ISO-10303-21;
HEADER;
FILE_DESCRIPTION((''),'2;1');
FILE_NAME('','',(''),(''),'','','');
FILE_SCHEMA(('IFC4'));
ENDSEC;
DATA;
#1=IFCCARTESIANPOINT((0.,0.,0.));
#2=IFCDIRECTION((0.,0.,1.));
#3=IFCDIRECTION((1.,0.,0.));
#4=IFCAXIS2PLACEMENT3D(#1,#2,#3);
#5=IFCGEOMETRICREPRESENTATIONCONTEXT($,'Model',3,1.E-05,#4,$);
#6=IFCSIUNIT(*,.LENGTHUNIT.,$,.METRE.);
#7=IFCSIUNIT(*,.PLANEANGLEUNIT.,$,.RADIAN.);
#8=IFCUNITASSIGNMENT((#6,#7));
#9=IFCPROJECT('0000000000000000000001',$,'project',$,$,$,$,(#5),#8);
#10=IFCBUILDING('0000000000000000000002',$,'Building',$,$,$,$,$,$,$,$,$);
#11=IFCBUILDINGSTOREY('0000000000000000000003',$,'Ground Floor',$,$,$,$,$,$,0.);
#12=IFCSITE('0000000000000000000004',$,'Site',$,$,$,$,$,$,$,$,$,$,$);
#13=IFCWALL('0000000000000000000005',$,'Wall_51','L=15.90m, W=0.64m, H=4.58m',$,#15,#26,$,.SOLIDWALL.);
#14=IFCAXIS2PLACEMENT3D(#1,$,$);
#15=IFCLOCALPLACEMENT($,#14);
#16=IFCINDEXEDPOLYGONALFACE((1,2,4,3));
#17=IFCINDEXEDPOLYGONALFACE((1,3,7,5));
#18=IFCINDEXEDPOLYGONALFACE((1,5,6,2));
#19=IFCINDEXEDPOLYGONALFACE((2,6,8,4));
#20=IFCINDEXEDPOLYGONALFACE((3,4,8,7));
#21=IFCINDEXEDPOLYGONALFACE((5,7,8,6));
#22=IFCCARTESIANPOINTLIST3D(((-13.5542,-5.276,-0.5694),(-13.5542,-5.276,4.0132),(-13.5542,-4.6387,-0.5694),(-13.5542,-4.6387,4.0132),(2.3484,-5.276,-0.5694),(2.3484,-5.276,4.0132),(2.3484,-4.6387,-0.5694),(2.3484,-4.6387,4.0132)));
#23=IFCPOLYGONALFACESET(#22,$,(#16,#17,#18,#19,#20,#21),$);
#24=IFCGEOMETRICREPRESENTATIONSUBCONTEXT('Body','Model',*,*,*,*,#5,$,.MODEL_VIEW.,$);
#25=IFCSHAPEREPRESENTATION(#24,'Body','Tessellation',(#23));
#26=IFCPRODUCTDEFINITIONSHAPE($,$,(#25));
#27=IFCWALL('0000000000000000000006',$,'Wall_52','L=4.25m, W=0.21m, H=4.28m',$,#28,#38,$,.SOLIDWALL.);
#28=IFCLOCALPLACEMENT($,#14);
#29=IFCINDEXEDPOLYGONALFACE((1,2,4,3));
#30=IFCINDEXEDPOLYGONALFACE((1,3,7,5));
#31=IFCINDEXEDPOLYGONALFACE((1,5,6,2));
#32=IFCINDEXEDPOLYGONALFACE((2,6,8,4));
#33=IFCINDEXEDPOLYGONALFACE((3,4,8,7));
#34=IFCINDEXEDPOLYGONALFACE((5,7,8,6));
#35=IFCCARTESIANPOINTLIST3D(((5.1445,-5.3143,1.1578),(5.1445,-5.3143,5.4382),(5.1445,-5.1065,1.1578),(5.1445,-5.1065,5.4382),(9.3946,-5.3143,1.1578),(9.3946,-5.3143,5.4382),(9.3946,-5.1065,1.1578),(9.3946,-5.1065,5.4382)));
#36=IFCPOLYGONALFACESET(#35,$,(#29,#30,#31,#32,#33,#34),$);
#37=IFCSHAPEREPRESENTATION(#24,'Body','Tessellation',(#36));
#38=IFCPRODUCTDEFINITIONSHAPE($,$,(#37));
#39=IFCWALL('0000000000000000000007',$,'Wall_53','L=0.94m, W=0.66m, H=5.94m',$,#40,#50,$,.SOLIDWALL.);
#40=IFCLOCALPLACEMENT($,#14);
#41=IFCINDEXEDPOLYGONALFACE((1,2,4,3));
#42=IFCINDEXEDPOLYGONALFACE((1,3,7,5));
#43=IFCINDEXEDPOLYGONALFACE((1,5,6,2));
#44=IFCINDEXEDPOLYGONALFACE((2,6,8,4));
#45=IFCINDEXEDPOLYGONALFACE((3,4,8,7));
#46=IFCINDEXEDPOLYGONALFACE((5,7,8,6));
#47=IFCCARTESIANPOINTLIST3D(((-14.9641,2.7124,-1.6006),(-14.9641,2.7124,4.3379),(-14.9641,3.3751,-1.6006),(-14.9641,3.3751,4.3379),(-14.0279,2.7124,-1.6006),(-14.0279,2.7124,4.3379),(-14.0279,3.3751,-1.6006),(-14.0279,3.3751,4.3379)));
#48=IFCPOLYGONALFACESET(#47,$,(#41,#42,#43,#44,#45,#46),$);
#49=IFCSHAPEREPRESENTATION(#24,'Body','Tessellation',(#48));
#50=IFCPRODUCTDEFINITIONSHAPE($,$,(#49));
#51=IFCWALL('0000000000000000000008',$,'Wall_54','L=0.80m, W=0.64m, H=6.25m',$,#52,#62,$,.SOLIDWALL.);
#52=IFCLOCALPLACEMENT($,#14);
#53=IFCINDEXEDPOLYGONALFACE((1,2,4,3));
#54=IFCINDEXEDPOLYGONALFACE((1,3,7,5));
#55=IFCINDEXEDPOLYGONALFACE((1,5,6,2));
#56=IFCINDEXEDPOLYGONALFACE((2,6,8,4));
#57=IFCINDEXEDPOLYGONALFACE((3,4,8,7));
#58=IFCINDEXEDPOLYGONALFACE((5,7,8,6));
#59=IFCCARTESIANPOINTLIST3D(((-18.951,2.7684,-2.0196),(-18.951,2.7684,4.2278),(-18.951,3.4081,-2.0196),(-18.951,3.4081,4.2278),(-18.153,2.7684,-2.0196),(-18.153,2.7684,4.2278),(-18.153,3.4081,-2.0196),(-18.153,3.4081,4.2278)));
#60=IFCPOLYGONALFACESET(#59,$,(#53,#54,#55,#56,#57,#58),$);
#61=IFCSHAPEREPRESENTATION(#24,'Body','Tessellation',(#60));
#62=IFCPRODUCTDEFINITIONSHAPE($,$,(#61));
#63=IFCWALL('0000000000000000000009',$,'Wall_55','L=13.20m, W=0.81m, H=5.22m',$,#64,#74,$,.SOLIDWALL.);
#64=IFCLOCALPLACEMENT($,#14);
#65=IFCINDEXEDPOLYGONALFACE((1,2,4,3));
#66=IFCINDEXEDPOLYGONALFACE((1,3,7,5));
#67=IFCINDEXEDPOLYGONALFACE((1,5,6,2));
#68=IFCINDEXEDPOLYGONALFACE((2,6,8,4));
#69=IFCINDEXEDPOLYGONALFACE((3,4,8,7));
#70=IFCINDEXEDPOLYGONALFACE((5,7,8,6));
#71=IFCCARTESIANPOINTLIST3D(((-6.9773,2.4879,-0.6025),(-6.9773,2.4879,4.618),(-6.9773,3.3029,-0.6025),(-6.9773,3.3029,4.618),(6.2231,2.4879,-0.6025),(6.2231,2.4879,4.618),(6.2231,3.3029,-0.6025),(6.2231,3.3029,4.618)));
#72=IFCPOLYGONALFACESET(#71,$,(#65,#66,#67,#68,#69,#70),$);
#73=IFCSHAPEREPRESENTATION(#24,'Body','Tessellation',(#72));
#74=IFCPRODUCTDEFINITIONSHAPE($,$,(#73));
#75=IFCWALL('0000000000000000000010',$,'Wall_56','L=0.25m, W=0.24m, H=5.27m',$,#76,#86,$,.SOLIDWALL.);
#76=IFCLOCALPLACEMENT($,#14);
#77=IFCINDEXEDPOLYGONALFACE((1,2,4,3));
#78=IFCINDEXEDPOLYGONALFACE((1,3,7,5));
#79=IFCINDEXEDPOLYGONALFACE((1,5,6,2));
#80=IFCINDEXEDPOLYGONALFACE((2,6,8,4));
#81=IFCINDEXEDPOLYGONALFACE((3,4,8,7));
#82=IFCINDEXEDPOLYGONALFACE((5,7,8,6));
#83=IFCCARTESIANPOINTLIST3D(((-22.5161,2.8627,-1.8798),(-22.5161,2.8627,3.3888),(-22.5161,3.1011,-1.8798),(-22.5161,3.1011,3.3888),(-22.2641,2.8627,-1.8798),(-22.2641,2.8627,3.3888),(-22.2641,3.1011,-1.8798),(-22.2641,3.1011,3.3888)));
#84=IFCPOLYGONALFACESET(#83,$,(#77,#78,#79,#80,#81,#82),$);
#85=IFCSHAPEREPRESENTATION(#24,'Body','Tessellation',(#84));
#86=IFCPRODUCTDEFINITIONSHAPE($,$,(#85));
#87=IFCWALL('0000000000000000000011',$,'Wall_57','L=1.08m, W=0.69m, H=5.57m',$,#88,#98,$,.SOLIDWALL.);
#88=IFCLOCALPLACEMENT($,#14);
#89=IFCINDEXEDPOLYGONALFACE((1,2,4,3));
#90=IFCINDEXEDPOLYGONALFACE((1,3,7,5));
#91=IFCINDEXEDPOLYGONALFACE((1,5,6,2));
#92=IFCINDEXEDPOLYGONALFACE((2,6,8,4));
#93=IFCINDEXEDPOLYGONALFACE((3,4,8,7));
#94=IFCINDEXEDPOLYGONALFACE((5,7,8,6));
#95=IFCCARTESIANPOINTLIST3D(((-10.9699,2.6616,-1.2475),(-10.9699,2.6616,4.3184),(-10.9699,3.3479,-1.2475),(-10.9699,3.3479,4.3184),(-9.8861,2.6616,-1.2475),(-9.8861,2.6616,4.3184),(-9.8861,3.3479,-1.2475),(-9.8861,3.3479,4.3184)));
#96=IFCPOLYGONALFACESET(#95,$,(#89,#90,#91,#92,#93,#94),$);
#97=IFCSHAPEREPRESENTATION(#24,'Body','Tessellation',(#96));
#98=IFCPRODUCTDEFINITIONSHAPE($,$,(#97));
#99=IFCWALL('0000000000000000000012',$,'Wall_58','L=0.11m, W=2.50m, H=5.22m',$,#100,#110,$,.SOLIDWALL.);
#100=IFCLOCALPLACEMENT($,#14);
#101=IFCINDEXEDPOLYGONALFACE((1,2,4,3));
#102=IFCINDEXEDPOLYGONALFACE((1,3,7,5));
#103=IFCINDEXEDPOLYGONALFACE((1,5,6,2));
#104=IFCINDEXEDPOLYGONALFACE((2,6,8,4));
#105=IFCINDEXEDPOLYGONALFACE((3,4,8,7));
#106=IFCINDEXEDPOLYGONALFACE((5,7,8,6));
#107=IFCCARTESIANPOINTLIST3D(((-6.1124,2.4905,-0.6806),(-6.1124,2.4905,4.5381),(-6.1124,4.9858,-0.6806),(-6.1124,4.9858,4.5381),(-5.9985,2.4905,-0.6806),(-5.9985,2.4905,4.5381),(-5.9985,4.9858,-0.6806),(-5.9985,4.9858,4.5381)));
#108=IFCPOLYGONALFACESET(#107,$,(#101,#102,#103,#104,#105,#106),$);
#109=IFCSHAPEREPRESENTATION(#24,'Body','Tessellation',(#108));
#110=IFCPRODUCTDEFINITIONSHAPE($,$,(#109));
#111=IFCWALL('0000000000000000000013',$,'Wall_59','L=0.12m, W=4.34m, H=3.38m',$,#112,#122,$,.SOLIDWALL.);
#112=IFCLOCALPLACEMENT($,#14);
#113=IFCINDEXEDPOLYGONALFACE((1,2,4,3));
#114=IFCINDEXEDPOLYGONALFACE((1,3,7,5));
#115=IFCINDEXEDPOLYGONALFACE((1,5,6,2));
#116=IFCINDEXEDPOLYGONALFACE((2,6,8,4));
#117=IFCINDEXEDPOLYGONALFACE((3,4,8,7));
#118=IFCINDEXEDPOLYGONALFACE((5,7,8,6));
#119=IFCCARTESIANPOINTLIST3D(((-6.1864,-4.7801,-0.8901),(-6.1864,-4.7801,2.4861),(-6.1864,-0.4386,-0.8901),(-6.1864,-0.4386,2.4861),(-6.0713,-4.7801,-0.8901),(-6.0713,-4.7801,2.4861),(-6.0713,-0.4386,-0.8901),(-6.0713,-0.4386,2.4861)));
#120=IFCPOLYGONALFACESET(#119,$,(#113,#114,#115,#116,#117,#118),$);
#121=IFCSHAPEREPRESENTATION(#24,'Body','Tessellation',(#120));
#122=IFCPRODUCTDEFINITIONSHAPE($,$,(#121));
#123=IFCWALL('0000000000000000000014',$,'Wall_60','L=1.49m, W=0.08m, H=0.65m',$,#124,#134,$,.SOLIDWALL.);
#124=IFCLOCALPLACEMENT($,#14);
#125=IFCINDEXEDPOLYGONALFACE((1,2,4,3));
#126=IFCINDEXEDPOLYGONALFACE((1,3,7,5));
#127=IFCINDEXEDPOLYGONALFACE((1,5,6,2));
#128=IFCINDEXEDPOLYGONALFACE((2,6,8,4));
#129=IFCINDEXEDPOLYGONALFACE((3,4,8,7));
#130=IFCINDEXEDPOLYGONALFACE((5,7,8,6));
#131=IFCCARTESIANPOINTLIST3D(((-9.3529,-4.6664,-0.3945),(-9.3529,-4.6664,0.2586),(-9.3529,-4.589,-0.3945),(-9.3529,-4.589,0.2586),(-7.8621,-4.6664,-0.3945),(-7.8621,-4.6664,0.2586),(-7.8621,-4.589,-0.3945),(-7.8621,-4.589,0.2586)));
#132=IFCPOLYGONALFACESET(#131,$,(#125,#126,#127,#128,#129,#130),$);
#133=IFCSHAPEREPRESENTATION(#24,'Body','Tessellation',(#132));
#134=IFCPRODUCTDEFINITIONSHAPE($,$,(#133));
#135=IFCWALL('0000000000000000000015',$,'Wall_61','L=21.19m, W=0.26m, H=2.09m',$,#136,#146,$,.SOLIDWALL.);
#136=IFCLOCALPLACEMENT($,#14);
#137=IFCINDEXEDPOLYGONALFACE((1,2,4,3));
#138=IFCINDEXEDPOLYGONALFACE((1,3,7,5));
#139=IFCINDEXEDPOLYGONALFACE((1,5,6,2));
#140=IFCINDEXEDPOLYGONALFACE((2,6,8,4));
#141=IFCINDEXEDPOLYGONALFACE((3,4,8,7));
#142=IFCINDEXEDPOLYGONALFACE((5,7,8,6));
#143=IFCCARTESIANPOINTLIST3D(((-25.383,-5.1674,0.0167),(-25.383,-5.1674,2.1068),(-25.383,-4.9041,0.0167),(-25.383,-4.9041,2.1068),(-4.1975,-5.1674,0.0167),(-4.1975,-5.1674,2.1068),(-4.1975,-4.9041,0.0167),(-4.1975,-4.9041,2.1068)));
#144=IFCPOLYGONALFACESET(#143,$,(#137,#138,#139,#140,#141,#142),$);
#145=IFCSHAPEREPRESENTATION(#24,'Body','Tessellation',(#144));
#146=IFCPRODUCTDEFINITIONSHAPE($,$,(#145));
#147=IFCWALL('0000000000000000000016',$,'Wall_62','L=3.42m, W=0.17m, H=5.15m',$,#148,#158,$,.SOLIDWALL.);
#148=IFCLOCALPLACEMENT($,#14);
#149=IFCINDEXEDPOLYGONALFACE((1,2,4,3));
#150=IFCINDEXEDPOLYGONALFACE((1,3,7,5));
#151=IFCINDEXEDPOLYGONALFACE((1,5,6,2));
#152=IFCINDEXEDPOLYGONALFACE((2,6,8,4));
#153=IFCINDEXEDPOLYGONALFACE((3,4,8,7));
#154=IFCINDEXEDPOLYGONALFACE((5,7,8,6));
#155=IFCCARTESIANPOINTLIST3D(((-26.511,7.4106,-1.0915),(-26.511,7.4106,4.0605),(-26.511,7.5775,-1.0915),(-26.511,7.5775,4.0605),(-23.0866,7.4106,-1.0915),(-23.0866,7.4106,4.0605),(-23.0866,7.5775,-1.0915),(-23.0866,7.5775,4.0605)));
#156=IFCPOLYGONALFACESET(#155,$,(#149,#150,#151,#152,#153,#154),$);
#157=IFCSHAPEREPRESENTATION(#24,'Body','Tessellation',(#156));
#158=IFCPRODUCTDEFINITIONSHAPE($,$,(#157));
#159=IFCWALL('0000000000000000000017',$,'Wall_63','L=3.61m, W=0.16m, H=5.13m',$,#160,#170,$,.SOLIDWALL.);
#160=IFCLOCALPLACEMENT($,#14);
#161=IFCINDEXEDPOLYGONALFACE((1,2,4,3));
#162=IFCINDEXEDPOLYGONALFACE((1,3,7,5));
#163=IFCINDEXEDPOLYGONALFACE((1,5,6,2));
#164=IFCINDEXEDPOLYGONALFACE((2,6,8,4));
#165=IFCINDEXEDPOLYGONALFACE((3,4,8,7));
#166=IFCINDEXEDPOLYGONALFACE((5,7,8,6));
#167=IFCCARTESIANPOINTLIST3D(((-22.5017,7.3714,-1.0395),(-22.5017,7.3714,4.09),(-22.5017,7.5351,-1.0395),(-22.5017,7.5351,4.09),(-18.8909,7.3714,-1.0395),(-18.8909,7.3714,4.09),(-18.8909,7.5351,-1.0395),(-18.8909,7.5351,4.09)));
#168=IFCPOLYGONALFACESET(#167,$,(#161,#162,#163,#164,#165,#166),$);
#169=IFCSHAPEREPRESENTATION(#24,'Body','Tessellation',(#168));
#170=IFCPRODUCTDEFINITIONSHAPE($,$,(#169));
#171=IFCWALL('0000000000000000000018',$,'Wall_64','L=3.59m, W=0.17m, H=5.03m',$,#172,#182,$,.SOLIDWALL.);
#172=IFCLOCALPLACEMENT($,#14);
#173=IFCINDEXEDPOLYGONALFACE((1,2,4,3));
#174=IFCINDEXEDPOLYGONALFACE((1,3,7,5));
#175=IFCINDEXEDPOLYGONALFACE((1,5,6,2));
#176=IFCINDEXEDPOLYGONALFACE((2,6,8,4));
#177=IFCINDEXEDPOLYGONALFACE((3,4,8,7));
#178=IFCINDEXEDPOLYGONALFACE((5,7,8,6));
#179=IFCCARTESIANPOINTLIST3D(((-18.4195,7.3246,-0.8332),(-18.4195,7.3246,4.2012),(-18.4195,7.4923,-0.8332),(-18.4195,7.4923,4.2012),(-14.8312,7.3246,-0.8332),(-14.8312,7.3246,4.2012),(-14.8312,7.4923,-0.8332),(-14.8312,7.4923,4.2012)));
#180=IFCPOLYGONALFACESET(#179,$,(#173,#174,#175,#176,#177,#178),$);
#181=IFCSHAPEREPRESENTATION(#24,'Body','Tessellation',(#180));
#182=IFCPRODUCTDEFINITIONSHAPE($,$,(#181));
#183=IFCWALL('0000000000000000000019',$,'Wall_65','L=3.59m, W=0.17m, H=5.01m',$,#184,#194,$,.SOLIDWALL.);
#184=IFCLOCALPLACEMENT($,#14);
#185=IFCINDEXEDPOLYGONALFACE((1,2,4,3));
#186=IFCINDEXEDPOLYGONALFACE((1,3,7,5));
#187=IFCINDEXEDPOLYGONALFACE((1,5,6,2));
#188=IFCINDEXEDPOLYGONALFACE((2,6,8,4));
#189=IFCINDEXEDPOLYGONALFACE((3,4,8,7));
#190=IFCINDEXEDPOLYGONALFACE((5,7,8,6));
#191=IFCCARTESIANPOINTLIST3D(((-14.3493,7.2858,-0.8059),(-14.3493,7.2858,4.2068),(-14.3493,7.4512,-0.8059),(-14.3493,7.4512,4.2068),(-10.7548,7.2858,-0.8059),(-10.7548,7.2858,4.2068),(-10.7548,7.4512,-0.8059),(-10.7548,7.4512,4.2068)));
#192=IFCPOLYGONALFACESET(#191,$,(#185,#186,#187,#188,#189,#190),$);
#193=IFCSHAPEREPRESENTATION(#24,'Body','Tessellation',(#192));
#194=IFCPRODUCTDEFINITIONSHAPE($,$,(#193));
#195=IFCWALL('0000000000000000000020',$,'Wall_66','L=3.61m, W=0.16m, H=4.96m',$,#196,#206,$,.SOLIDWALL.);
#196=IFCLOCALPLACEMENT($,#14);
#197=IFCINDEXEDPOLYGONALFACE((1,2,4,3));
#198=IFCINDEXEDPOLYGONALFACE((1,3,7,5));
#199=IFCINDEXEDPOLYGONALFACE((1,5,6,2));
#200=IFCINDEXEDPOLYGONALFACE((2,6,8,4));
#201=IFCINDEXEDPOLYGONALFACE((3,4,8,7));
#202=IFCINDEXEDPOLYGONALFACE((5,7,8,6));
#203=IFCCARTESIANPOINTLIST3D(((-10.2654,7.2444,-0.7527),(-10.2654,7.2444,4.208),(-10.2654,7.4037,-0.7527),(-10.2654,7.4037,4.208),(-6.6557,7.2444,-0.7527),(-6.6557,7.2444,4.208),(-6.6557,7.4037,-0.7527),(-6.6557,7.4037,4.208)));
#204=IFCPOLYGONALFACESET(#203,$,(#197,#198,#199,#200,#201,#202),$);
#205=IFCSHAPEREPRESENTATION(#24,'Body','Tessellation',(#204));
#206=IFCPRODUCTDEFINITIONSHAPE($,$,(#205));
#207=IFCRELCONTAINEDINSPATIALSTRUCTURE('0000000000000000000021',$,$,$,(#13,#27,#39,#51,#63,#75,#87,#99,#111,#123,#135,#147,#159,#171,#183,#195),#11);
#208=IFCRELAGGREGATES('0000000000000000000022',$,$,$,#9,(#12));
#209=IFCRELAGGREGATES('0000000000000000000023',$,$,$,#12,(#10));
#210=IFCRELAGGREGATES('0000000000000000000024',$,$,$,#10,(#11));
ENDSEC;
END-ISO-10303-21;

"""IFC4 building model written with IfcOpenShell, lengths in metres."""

from ifc_helpers import new_model, si_unit, frame, origin_with_axes, origin_2d, context, subcontext, project, spatial, rectangle, extrude, element, save


model = new_model("IFC4")

# Units and contexts
model_context = context("Model", 3, precision=1e-05, world=origin_with_axes())
body_context = subcontext(model_context, "Body", "Model", "MODEL_VIEW")
ifc_project = project(units=[si_unit("LENGTHUNIT", "METRE"), si_unit("PLANEANGLEUNIT", "RADIAN")], contexts=[model_context])

# Site, building, storey
site = spatial("IfcSite", under=ifc_project, Name="Site")
building = spatial("IfcBuilding", under=site, Name="Building")
storey = spatial("IfcBuildingStorey", under=building, Name="Ground Floor", Elevation=0.0)

# Walls
element("IfcWall", 1, inside=storey, Name="Wall_51", Description="L=15.90m, W=0.64m, H=4.58m", PredefinedType="SOLIDWALL", context=body_context, shape_type="SweptSolid", body=[
    extrude(rectangle(XDim=15.9026, YDim=0.6373, at=origin_2d()), frame((-5.6029, -4.9573, -0.5694), z_axis=(0.0, 0.0, 1.0), x_axis=(1.0, 0.0, 0.0)), (0.0, 0.0, 1.0), 4.5827),
])
element("IfcWall", 2, inside=storey, Name="Wall_52", Description="L=4.25m, W=0.21m, H=4.28m", PredefinedType="SOLIDWALL", context=body_context, shape_type="SweptSolid", body=[
    extrude(rectangle(XDim=4.2501, YDim=0.2079, at=origin_2d()), frame((7.2695, -5.2104, 1.1578), z_axis=(0.0, 0.0, 1.0), x_axis=(1.0, 0.0, 0.0)), (0.0, 0.0, 1.0), 4.2804),
])
element("IfcWall", 3, inside=storey, Name="Wall_53", Description="L=0.94m, W=0.66m, H=5.94m", PredefinedType="SOLIDWALL", context=body_context, shape_type="SweptSolid", body=[
    extrude(rectangle(XDim=0.9362, YDim=0.6626, at=origin_2d()), frame((-14.496, 3.0438, -1.6006), z_axis=(0.0, 0.0, 1.0), x_axis=(1.0, 0.0, 0.0)), (0.0, 0.0, 1.0), 5.9385),
])
element("IfcWall", 4, inside=storey, Name="Wall_54", Description="L=0.80m, W=0.64m, H=6.25m", PredefinedType="SOLIDWALL", context=body_context, shape_type="SweptSolid", body=[
    extrude(rectangle(XDim=0.7979, YDim=0.6396, at=origin_2d()), frame((-18.552, 3.0883, -2.0196), z_axis=(0.0, 0.0, 1.0), x_axis=(1.0, 0.0, 0.0)), (0.0, 0.0, 1.0), 6.2474),
])
element("IfcWall", 5, inside=storey, Name="Wall_55", Description="L=13.20m, W=0.81m, H=5.22m", PredefinedType="SOLIDWALL", context=body_context, shape_type="SweptSolid", body=[
    extrude(rectangle(XDim=13.2003, YDim=0.815, at=origin_2d()), frame((-0.3771, 2.8954, -0.6025), z_axis=(0.0, 0.0, 1.0), x_axis=(1.0, 0.0, 0.0)), (0.0, 0.0, 1.0), 5.2206),
])
element("IfcWall", 6, inside=storey, Name="Wall_56", Description="L=0.25m, W=0.24m, H=5.27m", PredefinedType="SOLIDWALL", context=body_context, shape_type="SweptSolid", body=[
    extrude(rectangle(XDim=0.252, YDim=0.2384, at=origin_2d()), frame((-22.3901, 2.9819, -1.8798), z_axis=(0.0, 0.0, 1.0), x_axis=(1.0, 0.0, 0.0)), (0.0, 0.0, 1.0), 5.2687),
])
element("IfcWall", 7, inside=storey, Name="Wall_57", Description="L=1.08m, W=0.69m, H=5.57m", PredefinedType="SOLIDWALL", context=body_context, shape_type="SweptSolid", body=[
    extrude(rectangle(XDim=1.0838, YDim=0.6863, at=origin_2d()), frame((-10.428, 3.0048, -1.2475), z_axis=(0.0, 0.0, 1.0), x_axis=(1.0, 0.0, 0.0)), (0.0, 0.0, 1.0), 5.5659),
])
element("IfcWall", 8, inside=storey, Name="Wall_58", Description="L=0.11m, W=2.50m, H=5.22m", PredefinedType="SOLIDWALL", context=body_context, shape_type="SweptSolid", body=[
    extrude(rectangle(XDim=0.114, YDim=2.4953, at=origin_2d()), frame((-6.0555, 3.7382, -0.6806), z_axis=(0.0, 0.0, 1.0), x_axis=(1.0, 0.0, 0.0)), (0.0, 0.0, 1.0), 5.2186),
])
element("IfcWall", 9, inside=storey, Name="Wall_59", Description="L=0.12m, W=4.34m, H=3.38m", PredefinedType="SOLIDWALL", context=body_context, shape_type="SweptSolid", body=[
    extrude(rectangle(XDim=0.1151, YDim=4.3415, at=origin_2d()), frame((-6.1289, -2.6094, -0.8901), z_axis=(0.0, 0.0, 1.0), x_axis=(1.0, 0.0, 0.0)), (0.0, 0.0, 1.0), 3.3762),
])
element("IfcWall", 10, inside=storey, Name="Wall_60", Description="L=1.49m, W=0.08m, H=0.65m", PredefinedType="SOLIDWALL", context=body_context, shape_type="SweptSolid", body=[
    extrude(rectangle(XDim=1.4908, YDim=0.0774, at=origin_2d()), frame((-8.6075, -4.6277, -0.3945), z_axis=(0.0, 0.0, 1.0), x_axis=(1.0, 0.0, 0.0)), (0.0, 0.0, 1.0), 0.6531),
])
element("IfcWall", 11, inside=storey, Name="Wall_61", Description="L=21.19m, W=0.26m, H=2.09m", PredefinedType="SOLIDWALL", context=body_context, shape_type="SweptSolid", body=[
    extrude(rectangle(XDim=21.1854, YDim=0.2632, at=origin_2d()), frame((-14.7902, -5.0357, 0.0167), z_axis=(0.0, 0.0, 1.0), x_axis=(1.0, 0.0, 0.0)), (0.0, 0.0, 1.0), 2.0901),
])
element("IfcWall", 12, inside=storey, Name="Wall_62", Description="L=3.42m, W=0.17m, H=5.15m", PredefinedType="SOLIDWALL", context=body_context, shape_type="SweptSolid", body=[
    extrude(rectangle(XDim=3.4244, YDim=0.1669, at=origin_2d()), frame((-24.7988, 7.494, -1.0915), z_axis=(0.0, 0.0, 1.0), x_axis=(1.0, 0.0, 0.0)), (0.0, 0.0, 1.0), 5.152),
])
element("IfcWall", 13, inside=storey, Name="Wall_63", Description="L=3.61m, W=0.16m, H=5.13m", PredefinedType="SOLIDWALL", context=body_context, shape_type="SweptSolid", body=[
    extrude(rectangle(XDim=3.6108, YDim=0.1637, at=origin_2d()), frame((-20.6963, 7.4533, -1.0395), z_axis=(0.0, 0.0, 1.0), x_axis=(1.0, 0.0, 0.0)), (0.0, 0.0, 1.0), 5.1295),
])
element("IfcWall", 14, inside=storey, Name="Wall_64", Description="L=3.59m, W=0.17m, H=5.03m", PredefinedType="SOLIDWALL", context=body_context, shape_type="SweptSolid", body=[
    extrude(rectangle(XDim=3.5883, YDim=0.1677, at=origin_2d()), frame((-16.6253, 7.4085, -0.8332), z_axis=(0.0, 0.0, 1.0), x_axis=(1.0, 0.0, 0.0)), (0.0, 0.0, 1.0), 5.0343),
])
element("IfcWall", 15, inside=storey, Name="Wall_65", Description="L=3.59m, W=0.17m, H=5.01m", PredefinedType="SOLIDWALL", context=body_context, shape_type="SweptSolid", body=[
    extrude(rectangle(XDim=3.5945, YDim=0.1655, at=origin_2d()), frame((-12.552, 7.3685, -0.8059), z_axis=(0.0, 0.0, 1.0), x_axis=(1.0, 0.0, 0.0)), (0.0, 0.0, 1.0), 5.0127),
])
element("IfcWall", 16, inside=storey, Name="Wall_66", Description="L=3.61m, W=0.16m, H=4.96m", PredefinedType="SOLIDWALL", context=body_context, shape_type="SweptSolid", body=[
    extrude(rectangle(XDim=3.6097, YDim=0.1593, at=origin_2d()), frame((-8.4605, 7.324, -0.7527), z_axis=(0.0, 0.0, 1.0), x_axis=(1.0, 0.0, 0.0)), (0.0, 0.0, 1.0), 4.9606),
])

save(model, "model.ifc")
